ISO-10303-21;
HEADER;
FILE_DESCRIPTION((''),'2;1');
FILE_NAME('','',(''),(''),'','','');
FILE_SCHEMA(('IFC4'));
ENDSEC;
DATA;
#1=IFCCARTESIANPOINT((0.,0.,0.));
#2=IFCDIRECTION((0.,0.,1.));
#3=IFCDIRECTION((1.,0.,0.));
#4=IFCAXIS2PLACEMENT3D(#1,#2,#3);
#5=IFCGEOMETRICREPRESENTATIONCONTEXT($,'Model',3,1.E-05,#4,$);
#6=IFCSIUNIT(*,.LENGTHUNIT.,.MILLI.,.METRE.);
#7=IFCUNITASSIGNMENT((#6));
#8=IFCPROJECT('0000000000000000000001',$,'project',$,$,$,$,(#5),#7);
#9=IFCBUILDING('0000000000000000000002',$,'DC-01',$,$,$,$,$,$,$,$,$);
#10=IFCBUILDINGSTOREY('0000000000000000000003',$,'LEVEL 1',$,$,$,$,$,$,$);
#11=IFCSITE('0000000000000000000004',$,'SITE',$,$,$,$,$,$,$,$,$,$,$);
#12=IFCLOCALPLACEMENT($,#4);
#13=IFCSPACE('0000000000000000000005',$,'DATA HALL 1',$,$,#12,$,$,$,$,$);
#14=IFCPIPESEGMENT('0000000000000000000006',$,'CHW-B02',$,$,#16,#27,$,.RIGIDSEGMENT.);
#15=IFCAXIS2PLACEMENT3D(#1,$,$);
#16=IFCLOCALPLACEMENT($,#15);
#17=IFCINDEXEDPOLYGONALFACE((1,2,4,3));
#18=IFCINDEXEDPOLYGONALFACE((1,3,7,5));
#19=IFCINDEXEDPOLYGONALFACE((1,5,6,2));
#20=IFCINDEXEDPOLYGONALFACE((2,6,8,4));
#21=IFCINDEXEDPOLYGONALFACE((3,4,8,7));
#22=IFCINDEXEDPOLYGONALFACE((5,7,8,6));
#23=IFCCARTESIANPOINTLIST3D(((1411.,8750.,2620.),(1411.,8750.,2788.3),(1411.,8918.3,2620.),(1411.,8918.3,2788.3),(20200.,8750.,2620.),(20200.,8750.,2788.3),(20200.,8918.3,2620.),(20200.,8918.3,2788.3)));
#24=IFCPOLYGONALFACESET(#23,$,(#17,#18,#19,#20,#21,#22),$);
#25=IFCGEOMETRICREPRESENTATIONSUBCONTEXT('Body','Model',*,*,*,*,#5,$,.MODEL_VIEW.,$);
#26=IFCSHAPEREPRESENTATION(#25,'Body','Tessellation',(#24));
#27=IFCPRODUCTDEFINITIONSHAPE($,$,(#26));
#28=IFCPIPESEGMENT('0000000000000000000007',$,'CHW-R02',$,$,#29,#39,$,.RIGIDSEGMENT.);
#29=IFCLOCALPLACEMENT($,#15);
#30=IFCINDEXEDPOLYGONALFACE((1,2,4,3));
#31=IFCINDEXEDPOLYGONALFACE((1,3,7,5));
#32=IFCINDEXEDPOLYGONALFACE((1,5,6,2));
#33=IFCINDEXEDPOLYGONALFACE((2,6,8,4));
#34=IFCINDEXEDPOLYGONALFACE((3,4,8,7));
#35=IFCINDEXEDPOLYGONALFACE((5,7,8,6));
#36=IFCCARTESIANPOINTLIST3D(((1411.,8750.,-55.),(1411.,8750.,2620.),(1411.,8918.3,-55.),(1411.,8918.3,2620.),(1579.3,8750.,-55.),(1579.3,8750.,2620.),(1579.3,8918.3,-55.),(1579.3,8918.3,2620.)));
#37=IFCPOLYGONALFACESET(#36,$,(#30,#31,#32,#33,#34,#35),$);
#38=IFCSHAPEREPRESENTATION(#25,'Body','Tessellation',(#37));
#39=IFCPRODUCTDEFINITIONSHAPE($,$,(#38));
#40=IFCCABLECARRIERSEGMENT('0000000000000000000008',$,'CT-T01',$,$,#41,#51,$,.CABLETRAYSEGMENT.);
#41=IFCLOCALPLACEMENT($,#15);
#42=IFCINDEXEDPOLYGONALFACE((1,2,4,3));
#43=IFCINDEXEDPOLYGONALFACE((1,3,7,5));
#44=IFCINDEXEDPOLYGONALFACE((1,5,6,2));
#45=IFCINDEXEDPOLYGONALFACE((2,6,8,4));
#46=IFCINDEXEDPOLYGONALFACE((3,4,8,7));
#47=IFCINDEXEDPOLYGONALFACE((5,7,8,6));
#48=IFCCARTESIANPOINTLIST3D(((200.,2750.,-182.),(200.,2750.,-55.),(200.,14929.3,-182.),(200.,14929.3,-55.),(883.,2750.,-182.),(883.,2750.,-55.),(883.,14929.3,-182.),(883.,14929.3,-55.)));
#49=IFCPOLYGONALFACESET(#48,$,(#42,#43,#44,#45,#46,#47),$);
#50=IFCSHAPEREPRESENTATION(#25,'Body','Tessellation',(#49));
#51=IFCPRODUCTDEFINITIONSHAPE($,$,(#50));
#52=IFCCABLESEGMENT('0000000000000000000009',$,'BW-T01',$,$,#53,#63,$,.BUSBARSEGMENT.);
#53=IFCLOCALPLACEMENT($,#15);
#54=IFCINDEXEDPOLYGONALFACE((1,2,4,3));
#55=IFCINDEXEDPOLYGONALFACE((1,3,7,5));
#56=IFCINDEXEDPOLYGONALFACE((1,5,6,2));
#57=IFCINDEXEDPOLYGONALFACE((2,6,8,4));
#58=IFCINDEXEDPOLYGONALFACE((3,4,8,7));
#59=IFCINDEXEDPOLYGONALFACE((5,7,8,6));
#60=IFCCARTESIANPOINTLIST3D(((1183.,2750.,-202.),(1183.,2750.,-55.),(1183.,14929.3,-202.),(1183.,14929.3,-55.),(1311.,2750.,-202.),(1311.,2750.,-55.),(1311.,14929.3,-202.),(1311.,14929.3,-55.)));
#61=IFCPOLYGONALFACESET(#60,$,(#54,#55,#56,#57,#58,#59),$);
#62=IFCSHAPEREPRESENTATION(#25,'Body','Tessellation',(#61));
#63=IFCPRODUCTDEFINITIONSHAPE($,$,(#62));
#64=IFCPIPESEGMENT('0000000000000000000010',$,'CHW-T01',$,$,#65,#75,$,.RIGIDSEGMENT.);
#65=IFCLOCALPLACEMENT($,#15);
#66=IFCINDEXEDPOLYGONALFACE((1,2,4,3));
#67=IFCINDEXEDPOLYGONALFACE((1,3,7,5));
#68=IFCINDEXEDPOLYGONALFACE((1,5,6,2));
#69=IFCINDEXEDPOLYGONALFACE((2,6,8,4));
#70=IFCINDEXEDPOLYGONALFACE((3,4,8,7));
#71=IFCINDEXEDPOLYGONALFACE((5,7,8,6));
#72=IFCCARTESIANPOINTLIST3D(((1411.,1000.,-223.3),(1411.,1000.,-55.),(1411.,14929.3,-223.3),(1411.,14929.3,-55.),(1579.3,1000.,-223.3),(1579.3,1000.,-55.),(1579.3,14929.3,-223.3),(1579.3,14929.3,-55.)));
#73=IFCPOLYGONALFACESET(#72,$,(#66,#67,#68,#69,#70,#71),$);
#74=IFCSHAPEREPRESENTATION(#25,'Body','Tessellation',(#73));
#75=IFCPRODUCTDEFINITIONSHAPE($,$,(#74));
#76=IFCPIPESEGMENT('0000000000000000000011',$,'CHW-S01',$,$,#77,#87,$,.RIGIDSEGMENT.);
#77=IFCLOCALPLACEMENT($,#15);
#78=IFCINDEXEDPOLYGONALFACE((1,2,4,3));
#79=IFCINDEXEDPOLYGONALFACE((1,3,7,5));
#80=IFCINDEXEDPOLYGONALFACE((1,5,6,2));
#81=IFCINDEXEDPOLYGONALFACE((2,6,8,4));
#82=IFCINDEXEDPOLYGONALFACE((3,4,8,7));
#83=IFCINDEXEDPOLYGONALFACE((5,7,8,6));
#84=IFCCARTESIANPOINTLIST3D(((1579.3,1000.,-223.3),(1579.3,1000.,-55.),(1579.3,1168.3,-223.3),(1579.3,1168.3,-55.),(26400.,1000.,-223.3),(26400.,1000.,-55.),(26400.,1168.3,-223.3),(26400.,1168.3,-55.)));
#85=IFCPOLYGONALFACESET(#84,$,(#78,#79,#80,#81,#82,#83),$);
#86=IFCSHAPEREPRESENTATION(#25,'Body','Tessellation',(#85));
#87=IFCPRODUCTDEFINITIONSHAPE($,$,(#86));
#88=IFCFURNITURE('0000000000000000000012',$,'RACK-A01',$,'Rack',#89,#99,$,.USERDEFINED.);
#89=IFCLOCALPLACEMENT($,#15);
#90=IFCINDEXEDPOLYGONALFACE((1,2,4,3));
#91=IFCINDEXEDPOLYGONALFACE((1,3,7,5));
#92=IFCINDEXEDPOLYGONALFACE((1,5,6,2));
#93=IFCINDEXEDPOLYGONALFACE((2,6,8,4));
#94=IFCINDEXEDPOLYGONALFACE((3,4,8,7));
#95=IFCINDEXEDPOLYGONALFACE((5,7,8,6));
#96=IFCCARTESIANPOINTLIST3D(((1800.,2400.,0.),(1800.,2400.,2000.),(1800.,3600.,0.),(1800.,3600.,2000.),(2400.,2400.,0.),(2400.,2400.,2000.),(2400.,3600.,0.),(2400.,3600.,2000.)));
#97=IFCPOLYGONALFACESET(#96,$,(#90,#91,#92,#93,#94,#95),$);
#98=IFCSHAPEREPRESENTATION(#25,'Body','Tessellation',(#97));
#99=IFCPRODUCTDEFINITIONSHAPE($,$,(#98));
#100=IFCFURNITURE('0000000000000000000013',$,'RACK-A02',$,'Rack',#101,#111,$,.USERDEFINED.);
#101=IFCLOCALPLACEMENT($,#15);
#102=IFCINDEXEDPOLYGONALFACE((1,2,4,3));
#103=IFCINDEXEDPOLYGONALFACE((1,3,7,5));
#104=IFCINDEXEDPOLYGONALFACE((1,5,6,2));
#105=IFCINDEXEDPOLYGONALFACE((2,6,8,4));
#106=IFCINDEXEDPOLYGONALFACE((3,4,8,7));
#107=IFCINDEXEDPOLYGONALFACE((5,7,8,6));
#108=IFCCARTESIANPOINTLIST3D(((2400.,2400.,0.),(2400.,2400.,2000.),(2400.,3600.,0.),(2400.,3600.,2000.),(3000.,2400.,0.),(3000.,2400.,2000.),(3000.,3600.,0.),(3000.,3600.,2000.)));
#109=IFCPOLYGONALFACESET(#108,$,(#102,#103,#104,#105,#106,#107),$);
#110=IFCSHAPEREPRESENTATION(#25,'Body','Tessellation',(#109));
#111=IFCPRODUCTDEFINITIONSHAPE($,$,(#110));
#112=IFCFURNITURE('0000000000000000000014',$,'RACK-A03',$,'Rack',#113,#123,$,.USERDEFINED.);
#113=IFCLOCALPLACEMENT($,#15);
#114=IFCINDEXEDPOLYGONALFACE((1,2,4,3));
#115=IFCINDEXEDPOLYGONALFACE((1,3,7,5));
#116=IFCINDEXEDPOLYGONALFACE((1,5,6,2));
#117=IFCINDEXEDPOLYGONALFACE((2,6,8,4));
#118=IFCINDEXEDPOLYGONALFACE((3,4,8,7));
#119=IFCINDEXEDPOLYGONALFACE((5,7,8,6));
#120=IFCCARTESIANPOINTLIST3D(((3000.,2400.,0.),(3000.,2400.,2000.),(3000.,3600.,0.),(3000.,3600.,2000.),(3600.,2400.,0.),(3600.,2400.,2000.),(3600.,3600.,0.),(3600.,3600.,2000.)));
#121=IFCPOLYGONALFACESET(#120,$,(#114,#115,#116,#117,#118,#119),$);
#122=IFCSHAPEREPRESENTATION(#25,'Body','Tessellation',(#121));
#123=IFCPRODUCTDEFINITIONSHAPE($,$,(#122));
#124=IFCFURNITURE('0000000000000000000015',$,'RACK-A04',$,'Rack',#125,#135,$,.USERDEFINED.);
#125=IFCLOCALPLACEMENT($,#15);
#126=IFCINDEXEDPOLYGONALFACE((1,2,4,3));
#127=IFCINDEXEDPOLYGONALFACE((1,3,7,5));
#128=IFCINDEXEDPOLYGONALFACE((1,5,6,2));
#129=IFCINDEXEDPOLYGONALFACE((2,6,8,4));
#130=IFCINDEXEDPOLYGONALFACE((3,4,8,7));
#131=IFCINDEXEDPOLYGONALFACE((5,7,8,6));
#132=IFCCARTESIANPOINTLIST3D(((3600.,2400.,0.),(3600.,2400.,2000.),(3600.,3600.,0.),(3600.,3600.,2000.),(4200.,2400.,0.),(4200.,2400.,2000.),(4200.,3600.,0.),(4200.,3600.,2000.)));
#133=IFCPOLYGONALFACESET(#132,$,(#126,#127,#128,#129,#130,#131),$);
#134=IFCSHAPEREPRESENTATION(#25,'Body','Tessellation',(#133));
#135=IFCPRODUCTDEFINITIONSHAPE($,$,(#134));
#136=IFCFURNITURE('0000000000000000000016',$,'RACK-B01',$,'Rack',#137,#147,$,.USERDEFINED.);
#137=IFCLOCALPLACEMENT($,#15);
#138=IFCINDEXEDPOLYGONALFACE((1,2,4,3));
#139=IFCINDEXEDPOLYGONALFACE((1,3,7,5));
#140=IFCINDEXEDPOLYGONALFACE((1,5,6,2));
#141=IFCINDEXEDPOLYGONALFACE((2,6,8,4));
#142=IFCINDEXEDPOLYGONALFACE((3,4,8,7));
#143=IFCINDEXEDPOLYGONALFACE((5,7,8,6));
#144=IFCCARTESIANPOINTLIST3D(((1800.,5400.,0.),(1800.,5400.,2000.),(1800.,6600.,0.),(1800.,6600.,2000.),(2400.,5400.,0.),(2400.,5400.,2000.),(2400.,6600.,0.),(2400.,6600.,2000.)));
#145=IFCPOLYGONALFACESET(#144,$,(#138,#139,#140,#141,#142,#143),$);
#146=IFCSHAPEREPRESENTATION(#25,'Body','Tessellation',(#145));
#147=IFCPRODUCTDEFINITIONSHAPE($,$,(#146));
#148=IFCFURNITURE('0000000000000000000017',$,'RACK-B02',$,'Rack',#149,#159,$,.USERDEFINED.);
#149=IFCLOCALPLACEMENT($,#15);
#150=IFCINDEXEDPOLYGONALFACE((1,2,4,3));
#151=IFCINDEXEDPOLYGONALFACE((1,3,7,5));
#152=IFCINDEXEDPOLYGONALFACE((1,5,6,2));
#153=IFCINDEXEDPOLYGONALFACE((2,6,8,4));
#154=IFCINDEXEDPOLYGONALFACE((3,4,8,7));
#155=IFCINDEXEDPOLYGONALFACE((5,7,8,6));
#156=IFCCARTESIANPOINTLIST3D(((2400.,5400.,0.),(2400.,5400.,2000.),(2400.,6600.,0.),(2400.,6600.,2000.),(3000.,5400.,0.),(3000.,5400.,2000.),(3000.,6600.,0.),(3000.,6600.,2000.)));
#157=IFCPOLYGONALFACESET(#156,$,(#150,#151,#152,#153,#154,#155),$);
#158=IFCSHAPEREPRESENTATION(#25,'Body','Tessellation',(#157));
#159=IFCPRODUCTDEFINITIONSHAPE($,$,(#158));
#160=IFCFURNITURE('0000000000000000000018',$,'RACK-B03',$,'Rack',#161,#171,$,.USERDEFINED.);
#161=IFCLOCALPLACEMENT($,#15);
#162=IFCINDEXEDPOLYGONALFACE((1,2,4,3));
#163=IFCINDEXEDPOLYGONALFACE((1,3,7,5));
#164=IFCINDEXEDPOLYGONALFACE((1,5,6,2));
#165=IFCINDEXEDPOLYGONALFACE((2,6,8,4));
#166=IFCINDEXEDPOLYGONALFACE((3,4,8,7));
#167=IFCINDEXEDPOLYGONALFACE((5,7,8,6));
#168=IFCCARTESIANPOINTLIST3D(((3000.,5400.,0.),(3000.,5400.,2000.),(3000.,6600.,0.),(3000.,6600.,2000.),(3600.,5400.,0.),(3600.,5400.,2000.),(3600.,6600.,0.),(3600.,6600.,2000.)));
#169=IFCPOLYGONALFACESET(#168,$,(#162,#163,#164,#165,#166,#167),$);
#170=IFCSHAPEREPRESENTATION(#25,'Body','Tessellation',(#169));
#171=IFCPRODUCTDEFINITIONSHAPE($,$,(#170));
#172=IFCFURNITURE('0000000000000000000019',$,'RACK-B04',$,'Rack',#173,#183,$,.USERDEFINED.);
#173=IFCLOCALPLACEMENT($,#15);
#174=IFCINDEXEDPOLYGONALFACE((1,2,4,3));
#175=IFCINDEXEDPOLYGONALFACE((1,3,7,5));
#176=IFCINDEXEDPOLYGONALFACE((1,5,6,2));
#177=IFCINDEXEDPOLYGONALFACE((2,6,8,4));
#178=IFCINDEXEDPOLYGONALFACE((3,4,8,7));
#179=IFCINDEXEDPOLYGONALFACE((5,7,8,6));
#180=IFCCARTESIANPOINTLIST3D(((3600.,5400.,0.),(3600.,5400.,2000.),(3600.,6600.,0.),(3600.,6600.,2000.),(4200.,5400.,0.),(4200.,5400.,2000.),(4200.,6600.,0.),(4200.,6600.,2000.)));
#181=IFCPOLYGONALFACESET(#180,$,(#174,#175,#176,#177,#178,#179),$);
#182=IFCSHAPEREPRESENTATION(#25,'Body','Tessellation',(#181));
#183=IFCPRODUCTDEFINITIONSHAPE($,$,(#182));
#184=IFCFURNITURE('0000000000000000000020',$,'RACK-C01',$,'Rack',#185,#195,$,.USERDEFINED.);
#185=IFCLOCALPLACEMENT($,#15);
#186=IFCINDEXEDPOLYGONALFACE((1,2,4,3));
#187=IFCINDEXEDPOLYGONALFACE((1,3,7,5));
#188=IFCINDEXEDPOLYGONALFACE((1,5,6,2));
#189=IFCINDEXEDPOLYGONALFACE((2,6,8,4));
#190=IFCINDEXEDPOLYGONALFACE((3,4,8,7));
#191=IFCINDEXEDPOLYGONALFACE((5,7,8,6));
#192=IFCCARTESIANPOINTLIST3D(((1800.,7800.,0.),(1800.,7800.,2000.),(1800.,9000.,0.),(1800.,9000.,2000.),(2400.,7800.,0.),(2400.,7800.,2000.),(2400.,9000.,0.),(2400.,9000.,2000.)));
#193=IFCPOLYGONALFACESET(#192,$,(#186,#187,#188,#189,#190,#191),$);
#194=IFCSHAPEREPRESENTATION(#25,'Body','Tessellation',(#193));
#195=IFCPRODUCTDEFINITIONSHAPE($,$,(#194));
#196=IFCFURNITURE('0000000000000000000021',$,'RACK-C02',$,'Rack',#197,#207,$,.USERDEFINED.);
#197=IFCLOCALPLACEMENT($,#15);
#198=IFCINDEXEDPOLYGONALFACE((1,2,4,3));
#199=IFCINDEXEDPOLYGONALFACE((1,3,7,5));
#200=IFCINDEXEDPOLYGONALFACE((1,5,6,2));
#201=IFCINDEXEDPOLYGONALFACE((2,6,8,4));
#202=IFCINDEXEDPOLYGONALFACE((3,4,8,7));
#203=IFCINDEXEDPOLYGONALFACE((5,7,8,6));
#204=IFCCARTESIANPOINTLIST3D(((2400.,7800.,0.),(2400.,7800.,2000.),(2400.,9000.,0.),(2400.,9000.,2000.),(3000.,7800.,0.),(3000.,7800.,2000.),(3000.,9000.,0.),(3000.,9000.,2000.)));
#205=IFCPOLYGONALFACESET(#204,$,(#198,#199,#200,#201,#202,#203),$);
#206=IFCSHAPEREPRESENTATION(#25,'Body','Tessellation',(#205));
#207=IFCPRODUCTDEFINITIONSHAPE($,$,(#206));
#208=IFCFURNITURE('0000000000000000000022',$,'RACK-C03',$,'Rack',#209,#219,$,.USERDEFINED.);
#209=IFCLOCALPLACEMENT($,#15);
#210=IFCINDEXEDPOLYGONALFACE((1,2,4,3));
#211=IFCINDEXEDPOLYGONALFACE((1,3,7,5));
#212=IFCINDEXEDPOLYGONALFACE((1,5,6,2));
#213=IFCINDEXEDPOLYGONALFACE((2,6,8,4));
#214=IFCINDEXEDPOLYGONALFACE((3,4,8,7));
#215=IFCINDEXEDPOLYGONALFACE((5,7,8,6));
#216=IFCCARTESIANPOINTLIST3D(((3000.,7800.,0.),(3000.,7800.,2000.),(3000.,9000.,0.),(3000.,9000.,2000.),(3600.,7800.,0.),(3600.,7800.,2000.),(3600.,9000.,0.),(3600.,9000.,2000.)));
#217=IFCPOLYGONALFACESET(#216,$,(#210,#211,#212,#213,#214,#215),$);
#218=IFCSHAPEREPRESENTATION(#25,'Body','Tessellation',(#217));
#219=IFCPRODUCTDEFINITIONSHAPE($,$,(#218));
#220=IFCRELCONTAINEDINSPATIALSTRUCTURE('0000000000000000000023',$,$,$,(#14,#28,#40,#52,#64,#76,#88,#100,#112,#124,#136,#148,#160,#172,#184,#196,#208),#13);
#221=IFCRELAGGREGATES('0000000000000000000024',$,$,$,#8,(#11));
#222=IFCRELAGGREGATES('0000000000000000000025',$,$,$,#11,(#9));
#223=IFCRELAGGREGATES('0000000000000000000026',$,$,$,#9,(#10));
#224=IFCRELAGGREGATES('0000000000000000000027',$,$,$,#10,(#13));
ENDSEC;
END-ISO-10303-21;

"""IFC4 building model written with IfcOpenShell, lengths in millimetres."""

from ifc_helpers import new_model, si_unit, frame, origin, origin_with_axes, place, context, subcontext, project, spatial, polyline, outline, extrude, element, save


model = new_model("IFC4")

# Units and contexts
model_context = context("Model", 3, precision=1e-05, world=origin_with_axes())
body_context = subcontext(model_context, "Body", "Model", "MODEL_VIEW")
ifc_project = project(units=[si_unit("LENGTHUNIT", "METRE", prefix="MILLI")], contexts=[model_context])

# Site, building, storey, space
site = spatial("IfcSite", under=ifc_project, Name="SITE")
building = spatial("IfcBuilding", under=site, Name="DC-01")
storey = spatial("IfcBuildingStorey", under=building, Name="LEVEL 1")
space_placement = place(None, origin_with_axes())
space = spatial("IfcSpace", under=storey, at=space_placement, Name="DATA HALL 1")

# Pipe segments
pipe_segment_1_placement = place(space_placement, frame((1411.0, 8750.0, 2620.0), z_axis=(0.0, 0.0, 1.0), x_axis=(1.0, 0.0, 0.0)))
element("IfcPipeSegment", 1, at=pipe_segment_1_placement, inside=space, Name="CHW-B02", PredefinedType="RIGIDSEGMENT", context=body_context, shape_type="SweptSolid", body=[
    extrude(outline(polyline([(0.0, 0.0), (18789.0, 0.0), (18789.0, 168.3), (0.0, 168.3), (0.0, 0.0)])), origin(), (0.0, 0.0, 1.0), 168.3),
])
pipe_segment_2_placement = place(space_placement, frame((1411.0, 8750.0, -55.0), z_axis=(0.0, 0.0, 1.0), x_axis=(1.0, 0.0, 0.0)))
element("IfcPipeSegment", 2, at=pipe_segment_2_placement, inside=space, Name="CHW-R02", PredefinedType="RIGIDSEGMENT", context=body_context, shape_type="SweptSolid", body=[
    extrude(outline(polyline([(0.0, 0.0), (168.3, 0.0), (168.3, 168.3), (0.0, 168.3), (0.0, 0.0)])), origin(), (0.0, 0.0, 1.0), 2675.0),
])

# Cable carrier segment
cable_carrier_segment_1_placement = place(space_placement, frame((200.0, 2750.0, -182.0), z_axis=(0.0, 0.0, 1.0), x_axis=(1.0, 0.0, 0.0)))
element("IfcCableCarrierSegment", 3, at=cable_carrier_segment_1_placement, inside=space, Name="CT-T01", PredefinedType="CABLETRAYSEGMENT", context=body_context, shape_type="SweptSolid", body=[
    extrude(outline(polyline([(0.0, 0.0), (683.0, 0.0), (683.0, 12179.3), (0.0, 12179.3), (0.0, 0.0)])), origin(), (0.0, 0.0, 1.0), 127.0),
])

# Cable segment
cable_segment_1_placement = place(space_placement, frame((1183.0, 2750.0, -202.0), z_axis=(0.0, 0.0, 1.0), x_axis=(1.0, 0.0, 0.0)))
element("IfcCableSegment", 4, at=cable_segment_1_placement, inside=space, Name="BW-T01", PredefinedType="BUSBARSEGMENT", context=body_context, shape_type="SweptSolid", body=[
    extrude(outline(polyline([(0.0, 0.0), (128.0, 0.0), (128.0, 12179.3), (0.0, 12179.3), (0.0, 0.0)])), origin(), (0.0, 0.0, 1.0), 147.0),
])

# Pipe segments
pipe_segment_3_placement = place(space_placement, frame((1411.0, 1000.0, -223.3), z_axis=(0.0, 0.0, 1.0), x_axis=(1.0, 0.0, 0.0)))
element("IfcPipeSegment", 5, at=pipe_segment_3_placement, inside=space, Name="CHW-T01", PredefinedType="RIGIDSEGMENT", context=body_context, shape_type="SweptSolid", body=[
    extrude(outline(polyline([(0.0, 0.0), (168.3, 0.0), (168.3, 13929.3), (0.0, 13929.3), (0.0, 0.0)])), origin(), (0.0, 0.0, 1.0), 168.3),
])
pipe_segment_4_placement = place(space_placement, frame((1579.3, 1000.0, -223.3), z_axis=(0.0, 0.0, 1.0), x_axis=(1.0, 0.0, 0.0)))
element("IfcPipeSegment", 6, at=pipe_segment_4_placement, inside=space, Name="CHW-S01", PredefinedType="RIGIDSEGMENT", context=body_context, shape_type="SweptSolid", body=[
    extrude(outline(polyline([(0.0, 0.0), (24820.7, 0.0), (24820.7, 168.3), (0.0, 168.3), (0.0, 0.0)])), origin(), (0.0, 0.0, 1.0), 168.3),
])

# Furniture
for number, where, z_axis, x_axis, name in (
    (7, (2400.0, 3600.0, 0.0), (0.0, 0.0, 1.0), (-1.0, 0.0, 0.0), "RACK-A01"),
    (8, (3000.0, 3600.0, 0.0), (0.0, 0.0, 1.0), (-1.0, 0.0, 0.0), "RACK-A02"),
    (9, (3600.0, 3600.0, 0.0), (0.0, 0.0, 1.0), (-1.0, 0.0, 0.0), "RACK-A03"),
    (10, (4200.0, 3600.0, 0.0), (0.0, 0.0, 1.0), (-1.0, 0.0, 0.0), "RACK-A04"),
    (11, (1800.0, 5400.0, 0.0), (0.0, 0.0, 1.0), (1.0, 0.0, 0.0), "RACK-B01"),
    (12, (2400.0, 5400.0, 0.0), (0.0, 0.0, 1.0), (1.0, 0.0, 0.0), "RACK-B02"),
    (13, (3000.0, 5400.0, 0.0), (0.0, 0.0, 1.0), (1.0, 0.0, 0.0), "RACK-B03"),
    (14, (3600.0, 5400.0, 0.0), (0.0, 0.0, 1.0), (1.0, 0.0, 0.0), "RACK-B04"),
    (15, (2400.0, 9000.0, 0.0), (0.0, 0.0, 1.0), (-1.0, 0.0, 0.0), "RACK-C01"),
    (16, (3000.0, 9000.0, 0.0), (0.0, 0.0, 1.0), (-1.0, 0.0, 0.0), "RACK-C02"),
    (17, (3600.0, 9000.0, 0.0), (0.0, 0.0, 1.0), (-1.0, 0.0, 0.0), "RACK-C03"),
):
    element("IfcFurniture", number, at=place(space_placement, frame(where, z_axis=z_axis, x_axis=x_axis)), inside=space, Name=name, ObjectType="Rack", PredefinedType="USERDEFINED", context=body_context, shape_type="SweptSolid", body=[
        extrude(outline(polyline([(0.0, 0.0), (600.0, 0.0), (600.0, 1200.0), (0.0, 1200.0), (0.0, 0.0)])), origin(), (0.0, 0.0, 1.0), 2000.0),
    ])

save(model, "model.ifc")
